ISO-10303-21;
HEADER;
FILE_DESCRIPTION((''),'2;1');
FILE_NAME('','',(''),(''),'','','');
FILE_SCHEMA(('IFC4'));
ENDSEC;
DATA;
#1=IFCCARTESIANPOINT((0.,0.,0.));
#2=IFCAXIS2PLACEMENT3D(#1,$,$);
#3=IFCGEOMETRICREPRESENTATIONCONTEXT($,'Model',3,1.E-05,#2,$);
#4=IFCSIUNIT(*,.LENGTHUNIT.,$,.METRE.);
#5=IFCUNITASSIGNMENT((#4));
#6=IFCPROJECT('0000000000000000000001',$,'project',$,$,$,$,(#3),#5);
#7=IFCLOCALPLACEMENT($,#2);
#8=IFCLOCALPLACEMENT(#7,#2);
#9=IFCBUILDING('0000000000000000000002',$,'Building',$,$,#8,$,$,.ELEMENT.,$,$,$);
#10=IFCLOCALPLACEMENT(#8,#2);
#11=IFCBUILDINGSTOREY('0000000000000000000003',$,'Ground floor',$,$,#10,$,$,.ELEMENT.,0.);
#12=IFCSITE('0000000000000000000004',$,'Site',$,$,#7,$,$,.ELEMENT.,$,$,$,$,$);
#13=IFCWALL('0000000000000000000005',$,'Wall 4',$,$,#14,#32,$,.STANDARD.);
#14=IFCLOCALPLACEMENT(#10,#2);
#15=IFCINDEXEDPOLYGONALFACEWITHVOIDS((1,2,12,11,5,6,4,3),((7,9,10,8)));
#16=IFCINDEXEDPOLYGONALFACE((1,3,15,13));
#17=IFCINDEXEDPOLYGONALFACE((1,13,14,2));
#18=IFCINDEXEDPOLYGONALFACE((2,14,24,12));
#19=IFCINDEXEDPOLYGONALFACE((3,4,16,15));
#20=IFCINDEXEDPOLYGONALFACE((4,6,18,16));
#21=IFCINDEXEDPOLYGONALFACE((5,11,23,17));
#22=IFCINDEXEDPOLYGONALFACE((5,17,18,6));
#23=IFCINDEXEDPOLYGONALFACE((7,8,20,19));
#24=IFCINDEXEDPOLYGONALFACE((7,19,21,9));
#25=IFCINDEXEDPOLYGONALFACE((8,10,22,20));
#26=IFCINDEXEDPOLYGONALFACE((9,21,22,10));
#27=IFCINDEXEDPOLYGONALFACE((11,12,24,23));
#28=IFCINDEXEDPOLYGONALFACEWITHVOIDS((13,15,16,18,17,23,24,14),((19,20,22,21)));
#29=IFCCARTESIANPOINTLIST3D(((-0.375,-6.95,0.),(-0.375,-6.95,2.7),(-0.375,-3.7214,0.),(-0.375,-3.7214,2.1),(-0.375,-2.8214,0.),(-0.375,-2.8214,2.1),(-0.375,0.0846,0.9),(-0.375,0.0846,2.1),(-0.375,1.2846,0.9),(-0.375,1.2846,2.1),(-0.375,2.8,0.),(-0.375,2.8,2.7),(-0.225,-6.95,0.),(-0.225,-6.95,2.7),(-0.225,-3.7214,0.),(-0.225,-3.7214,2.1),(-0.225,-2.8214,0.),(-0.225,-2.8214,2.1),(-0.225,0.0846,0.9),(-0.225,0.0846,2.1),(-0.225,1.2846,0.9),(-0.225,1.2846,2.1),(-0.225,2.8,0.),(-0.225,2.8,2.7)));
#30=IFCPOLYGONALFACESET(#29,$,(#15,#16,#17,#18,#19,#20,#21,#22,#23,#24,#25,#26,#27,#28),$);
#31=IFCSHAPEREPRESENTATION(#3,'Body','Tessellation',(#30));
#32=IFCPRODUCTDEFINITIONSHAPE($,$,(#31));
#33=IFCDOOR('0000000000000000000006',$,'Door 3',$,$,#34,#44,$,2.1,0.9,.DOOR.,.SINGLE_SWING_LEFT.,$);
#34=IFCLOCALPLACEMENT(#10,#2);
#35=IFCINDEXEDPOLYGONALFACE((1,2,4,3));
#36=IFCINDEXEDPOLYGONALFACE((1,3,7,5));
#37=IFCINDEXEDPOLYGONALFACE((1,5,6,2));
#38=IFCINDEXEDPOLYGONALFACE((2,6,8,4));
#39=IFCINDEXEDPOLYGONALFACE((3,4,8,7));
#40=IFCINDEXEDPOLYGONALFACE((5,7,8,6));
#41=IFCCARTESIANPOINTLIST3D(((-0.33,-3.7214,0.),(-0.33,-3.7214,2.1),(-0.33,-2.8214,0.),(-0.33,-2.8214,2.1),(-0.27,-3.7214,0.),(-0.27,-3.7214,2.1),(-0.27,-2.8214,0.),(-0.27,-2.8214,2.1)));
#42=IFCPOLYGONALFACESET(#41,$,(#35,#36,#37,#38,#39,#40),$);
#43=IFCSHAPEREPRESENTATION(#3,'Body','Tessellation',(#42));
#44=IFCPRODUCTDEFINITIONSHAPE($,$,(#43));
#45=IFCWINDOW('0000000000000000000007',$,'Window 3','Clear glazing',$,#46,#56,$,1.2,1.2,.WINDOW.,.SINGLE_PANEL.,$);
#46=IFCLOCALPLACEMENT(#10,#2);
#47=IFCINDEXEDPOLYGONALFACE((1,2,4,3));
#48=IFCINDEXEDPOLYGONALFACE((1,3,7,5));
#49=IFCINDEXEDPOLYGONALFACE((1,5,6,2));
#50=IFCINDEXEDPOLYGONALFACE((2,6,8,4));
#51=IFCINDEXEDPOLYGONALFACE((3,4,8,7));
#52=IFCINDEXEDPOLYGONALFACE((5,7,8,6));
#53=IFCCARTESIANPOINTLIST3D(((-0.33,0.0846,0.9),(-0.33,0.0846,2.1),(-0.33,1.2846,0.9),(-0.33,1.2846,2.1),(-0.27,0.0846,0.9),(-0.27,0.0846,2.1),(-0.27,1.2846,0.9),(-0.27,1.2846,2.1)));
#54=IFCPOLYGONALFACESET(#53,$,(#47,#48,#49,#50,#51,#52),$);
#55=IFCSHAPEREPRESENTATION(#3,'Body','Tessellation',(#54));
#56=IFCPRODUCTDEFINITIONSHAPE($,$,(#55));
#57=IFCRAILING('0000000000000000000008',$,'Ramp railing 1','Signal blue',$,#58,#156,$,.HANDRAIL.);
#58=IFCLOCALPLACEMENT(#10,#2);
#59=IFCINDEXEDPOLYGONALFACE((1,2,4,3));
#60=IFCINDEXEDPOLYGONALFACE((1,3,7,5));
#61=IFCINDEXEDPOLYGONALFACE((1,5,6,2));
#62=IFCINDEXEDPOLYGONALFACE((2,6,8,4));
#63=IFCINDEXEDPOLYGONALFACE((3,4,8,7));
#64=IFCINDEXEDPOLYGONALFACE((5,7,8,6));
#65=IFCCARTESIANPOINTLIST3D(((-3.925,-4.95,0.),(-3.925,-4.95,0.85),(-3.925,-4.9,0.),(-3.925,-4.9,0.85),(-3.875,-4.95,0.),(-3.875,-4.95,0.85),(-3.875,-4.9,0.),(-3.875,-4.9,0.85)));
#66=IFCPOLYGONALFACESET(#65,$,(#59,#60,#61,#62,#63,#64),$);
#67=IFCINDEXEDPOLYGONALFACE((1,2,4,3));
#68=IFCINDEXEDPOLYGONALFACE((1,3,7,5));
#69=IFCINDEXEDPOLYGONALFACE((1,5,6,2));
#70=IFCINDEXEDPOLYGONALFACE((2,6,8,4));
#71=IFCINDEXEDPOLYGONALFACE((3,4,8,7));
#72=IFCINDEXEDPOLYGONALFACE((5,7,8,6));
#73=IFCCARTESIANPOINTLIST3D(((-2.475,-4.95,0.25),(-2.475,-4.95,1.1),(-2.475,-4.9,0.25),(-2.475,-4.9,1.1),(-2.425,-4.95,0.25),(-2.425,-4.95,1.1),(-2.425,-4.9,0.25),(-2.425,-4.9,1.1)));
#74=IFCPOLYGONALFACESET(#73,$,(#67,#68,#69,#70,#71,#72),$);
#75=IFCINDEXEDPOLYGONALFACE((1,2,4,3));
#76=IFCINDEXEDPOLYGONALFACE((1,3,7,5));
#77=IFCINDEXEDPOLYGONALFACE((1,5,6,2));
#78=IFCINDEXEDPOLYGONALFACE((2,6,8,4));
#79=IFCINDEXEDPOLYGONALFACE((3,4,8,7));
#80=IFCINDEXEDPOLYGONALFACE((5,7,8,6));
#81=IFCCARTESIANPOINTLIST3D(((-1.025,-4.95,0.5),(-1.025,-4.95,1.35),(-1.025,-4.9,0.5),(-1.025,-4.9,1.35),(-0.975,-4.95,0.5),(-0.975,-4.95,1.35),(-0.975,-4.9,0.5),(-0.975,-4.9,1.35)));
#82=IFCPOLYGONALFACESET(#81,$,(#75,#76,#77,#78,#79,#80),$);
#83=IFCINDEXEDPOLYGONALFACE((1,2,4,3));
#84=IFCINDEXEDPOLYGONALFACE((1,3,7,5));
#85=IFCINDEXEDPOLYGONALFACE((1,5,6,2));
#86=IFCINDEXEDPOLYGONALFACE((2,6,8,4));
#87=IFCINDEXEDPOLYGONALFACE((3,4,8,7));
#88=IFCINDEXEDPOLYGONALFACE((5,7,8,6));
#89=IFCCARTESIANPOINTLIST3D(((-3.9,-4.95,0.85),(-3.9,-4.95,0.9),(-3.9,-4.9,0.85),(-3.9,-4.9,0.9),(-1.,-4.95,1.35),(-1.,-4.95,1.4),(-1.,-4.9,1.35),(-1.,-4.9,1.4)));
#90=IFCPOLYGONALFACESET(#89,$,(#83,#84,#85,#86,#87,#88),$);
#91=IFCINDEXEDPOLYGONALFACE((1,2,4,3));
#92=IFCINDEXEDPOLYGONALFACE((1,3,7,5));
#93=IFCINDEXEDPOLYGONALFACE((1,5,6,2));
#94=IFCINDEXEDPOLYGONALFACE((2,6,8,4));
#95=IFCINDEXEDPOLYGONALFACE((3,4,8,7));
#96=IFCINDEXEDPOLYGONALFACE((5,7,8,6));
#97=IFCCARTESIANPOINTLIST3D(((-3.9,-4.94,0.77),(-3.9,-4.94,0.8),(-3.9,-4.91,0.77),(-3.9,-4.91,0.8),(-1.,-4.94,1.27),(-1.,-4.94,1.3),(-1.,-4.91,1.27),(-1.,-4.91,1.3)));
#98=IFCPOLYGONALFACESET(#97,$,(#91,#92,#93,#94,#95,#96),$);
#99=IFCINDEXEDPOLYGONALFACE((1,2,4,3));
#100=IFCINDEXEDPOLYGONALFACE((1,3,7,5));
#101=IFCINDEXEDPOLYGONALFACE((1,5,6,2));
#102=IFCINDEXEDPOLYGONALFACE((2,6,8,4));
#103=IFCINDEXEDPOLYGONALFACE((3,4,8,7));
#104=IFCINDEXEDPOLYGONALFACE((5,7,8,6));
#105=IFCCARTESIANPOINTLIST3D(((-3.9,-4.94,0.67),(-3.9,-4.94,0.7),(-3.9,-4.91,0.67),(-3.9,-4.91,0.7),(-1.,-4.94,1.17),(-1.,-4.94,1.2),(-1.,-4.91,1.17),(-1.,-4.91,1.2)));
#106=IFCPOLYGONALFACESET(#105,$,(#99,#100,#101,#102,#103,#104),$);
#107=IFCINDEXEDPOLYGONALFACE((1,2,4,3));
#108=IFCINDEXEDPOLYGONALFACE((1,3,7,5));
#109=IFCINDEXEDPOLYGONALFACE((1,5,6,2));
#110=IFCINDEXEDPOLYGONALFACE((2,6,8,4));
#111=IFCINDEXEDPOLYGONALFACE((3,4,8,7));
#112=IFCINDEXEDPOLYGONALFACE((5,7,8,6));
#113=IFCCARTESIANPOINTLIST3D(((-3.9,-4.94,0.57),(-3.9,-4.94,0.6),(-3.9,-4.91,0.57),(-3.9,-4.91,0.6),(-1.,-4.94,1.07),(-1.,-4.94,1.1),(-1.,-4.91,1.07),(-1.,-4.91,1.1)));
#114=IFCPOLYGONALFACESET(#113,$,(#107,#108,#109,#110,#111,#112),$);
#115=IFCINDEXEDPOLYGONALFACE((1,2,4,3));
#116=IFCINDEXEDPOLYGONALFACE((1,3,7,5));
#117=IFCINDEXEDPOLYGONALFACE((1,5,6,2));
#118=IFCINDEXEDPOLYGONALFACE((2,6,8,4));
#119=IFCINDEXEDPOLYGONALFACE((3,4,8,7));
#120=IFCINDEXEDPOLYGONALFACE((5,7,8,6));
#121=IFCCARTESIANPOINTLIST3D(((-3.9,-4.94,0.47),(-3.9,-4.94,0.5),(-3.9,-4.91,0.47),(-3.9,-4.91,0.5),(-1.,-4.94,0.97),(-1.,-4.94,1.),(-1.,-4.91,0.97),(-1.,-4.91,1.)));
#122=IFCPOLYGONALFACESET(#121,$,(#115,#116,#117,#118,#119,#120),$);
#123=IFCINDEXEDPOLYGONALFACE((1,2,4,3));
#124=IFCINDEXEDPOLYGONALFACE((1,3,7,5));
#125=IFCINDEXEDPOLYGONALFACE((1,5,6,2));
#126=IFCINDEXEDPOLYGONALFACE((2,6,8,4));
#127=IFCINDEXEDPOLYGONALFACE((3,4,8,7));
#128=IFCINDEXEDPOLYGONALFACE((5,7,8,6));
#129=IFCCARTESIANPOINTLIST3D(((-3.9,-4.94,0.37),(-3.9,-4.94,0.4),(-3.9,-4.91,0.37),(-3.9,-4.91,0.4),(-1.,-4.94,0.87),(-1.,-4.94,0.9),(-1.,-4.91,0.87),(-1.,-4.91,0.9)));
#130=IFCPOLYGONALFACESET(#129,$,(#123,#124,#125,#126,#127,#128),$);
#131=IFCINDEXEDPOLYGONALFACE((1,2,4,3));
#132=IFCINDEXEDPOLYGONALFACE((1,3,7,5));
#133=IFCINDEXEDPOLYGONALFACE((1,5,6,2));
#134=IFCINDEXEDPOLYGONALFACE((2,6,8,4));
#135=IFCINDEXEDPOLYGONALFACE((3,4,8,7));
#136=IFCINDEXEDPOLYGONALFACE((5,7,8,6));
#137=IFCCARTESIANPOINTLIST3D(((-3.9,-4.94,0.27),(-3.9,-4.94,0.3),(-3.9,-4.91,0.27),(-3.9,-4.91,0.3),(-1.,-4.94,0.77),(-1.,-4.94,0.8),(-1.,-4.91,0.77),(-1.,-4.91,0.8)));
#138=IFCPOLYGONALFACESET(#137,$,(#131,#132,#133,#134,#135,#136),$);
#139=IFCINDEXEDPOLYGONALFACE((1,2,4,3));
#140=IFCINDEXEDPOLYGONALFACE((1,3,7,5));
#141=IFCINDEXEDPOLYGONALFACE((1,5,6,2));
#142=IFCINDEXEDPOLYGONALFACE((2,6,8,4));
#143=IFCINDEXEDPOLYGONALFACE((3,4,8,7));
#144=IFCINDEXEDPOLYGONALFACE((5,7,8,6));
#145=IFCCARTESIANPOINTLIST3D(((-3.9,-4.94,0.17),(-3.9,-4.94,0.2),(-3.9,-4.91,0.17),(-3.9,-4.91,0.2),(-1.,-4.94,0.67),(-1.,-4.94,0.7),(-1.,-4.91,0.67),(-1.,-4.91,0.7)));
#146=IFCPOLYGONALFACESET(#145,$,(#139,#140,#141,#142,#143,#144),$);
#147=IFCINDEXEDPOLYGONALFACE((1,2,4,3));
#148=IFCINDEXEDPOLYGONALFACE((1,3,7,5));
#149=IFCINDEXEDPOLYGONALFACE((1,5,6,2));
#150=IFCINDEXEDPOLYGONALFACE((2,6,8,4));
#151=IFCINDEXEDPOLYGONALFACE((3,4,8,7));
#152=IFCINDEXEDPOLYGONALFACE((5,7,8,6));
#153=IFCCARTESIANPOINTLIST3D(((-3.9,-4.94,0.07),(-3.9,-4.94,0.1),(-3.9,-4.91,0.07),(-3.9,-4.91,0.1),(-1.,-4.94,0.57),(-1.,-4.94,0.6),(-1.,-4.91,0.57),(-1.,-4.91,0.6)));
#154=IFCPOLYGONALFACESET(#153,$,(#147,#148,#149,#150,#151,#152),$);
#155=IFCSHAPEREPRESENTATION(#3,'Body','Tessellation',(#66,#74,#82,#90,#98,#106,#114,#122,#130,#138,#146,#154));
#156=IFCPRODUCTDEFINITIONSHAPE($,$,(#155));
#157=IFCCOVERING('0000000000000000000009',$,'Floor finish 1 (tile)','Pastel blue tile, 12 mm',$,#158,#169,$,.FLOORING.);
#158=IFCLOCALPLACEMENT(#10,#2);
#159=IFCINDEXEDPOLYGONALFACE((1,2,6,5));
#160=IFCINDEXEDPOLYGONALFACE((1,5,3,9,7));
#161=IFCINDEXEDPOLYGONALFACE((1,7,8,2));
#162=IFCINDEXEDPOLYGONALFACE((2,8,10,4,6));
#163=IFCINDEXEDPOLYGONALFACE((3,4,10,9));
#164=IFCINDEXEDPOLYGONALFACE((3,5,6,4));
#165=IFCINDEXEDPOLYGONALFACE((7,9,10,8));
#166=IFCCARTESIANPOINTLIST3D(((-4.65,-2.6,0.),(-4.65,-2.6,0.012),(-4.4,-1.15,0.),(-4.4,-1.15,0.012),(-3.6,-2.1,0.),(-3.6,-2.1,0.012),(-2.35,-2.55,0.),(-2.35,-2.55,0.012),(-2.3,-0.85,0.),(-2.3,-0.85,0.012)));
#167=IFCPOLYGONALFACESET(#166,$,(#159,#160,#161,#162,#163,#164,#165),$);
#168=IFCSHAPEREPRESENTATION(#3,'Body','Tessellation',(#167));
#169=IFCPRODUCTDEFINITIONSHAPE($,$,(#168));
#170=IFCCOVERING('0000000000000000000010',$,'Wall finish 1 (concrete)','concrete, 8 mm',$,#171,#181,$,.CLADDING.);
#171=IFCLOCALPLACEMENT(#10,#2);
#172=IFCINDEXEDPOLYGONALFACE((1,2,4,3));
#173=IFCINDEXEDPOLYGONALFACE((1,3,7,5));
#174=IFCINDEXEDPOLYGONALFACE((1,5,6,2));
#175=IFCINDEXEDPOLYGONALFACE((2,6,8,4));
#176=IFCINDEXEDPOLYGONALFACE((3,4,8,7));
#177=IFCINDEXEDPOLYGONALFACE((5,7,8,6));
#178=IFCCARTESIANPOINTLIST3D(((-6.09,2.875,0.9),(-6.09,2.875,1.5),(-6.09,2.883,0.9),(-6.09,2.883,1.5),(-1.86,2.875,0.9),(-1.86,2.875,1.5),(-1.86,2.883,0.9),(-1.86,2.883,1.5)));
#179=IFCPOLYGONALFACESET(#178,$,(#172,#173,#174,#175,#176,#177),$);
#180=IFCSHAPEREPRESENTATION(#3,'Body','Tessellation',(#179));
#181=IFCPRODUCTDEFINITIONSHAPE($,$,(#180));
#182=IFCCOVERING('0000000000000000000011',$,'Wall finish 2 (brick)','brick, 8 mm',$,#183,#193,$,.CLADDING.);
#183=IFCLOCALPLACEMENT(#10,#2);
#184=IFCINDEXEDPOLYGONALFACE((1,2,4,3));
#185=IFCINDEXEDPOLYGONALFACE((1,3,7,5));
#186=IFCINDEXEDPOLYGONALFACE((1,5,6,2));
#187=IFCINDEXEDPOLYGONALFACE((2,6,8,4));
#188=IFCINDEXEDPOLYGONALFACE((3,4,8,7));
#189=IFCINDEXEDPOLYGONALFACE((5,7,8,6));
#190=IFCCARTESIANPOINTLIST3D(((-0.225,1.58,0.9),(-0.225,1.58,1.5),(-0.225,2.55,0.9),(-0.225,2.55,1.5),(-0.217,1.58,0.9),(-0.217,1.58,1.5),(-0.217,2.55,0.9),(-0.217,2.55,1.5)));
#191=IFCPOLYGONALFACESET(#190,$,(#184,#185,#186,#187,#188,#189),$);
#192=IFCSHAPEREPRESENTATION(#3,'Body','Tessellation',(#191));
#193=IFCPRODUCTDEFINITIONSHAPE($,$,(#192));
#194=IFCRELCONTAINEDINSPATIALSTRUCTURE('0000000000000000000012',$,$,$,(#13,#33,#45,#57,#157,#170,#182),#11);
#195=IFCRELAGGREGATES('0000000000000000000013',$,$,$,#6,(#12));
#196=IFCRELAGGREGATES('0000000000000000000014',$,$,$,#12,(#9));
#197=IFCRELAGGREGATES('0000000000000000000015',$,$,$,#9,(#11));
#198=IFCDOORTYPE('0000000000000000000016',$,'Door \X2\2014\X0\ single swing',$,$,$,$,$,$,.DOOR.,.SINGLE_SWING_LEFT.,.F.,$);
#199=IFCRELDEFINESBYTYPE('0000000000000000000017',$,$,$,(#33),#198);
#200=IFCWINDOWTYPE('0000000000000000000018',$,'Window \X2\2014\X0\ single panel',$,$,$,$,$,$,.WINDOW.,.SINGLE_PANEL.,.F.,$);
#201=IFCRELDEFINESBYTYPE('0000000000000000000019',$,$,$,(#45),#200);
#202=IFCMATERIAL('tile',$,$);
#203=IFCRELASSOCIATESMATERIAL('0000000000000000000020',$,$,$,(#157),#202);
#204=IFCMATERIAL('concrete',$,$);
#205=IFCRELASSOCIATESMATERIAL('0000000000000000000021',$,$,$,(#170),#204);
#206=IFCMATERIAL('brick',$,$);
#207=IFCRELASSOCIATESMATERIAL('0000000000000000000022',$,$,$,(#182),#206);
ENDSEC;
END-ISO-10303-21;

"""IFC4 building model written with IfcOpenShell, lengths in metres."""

from ifc_helpers import new_model, si_unit, frame, frame_2d, origin, origin_with_axes, place, context, project, spatial, polyline, rectangle, outline, extrude, material, type_object, element, fill, save


model = new_model("IFC4")

# Units and contexts
model_context = context("Model", 3, precision=1e-05, world=origin())
ifc_project = project(units=[si_unit("LENGTHUNIT", "METRE")], contexts=[model_context])

# Site, building, storey
site_placement = place(None, origin())
site = spatial("IfcSite", under=ifc_project, at=site_placement, Name="Site", CompositionType="ELEMENT")
building_placement = place(site_placement, origin())
building = spatial("IfcBuilding", under=site, at=building_placement, Name="Building", CompositionType="ELEMENT")
storey_placement = place(building_placement, origin())
storey = spatial("IfcBuildingStorey", under=building, at=storey_placement, Name="Ground floor", CompositionType="ELEMENT", Elevation=0.0)

# Shared definitions
door_type = type_object("IfcDoorType", Name="Door — single swing", OperationType="SINGLE_SWING_LEFT", ParameterTakesPrecedence=False, PredefinedType="DOOR")
window_type_1 = type_object("IfcWindowType", Name="Window — single panel", ParameterTakesPrecedence=False, PartitioningType="SINGLE_PANEL", PredefinedType="WINDOW")

# Wall, openings, door, window
wall_1_placement = place(storey_placement, frame((-0.3, 2.8, 0.0), z_axis=(0.0, 0.0, 1.0), x_axis=(0.0, -1.0, 0.0)))
wall_1 = element("IfcWall", 1, at=wall_1_placement, inside=storey, Name="Wall 4", PredefinedType="STANDARD", context=model_context, shape_type="SweptSolid", body=[
    extrude(rectangle(XDim=9.75, YDim=0.15, at=frame_2d((4.875, 0.0))), origin(), (0.0, 0.0, 1.0), 2.7),
])
opening_1_placement = place(storey_placement, frame((-0.3, 1.2846, 0.9), z_axis=(0.0, 0.0, 1.0), x_axis=(0.0, -1.0, 0.0)))
opening_1 = element("IfcOpeningElement", 2, at=opening_1_placement, cuts=wall_1, PredefinedType="OPENING", context=model_context, shape_type="SweptSolid", body=[
    extrude(rectangle(XDim=1.2, YDim=0.21, at=frame_2d((0.6, 0.0))), origin(), (0.0, 0.0, 1.0), 1.2),
])
opening_2_placement = place(storey_placement, frame((-0.3, -2.8214, 0.0), z_axis=(0.0, 0.0, 1.0), x_axis=(0.0, -1.0, 0.0)))
opening_2 = element("IfcOpeningElement", 3, at=opening_2_placement, cuts=wall_1, PredefinedType="OPENING", context=model_context, shape_type="SweptSolid", body=[
    extrude(rectangle(XDim=0.9, YDim=0.21, at=frame_2d((0.45, 0.0))), origin(), (0.0, 0.0, 1.0), 2.1),
])
door_1_placement = place(storey_placement, frame((-0.3, -2.8214, 0.0), z_axis=(0.0, 0.0, 1.0), x_axis=(0.0, -1.0, 0.0)))
door_1 = element("IfcDoor", 4, at=door_1_placement, inside=storey, type_object=door_type, Name="Door 3", OperationType="SINGLE_SWING_LEFT", OverallHeight=2.1, OverallWidth=0.9, PredefinedType="DOOR", context=model_context, shape_type="SweptSolid", body=[
    extrude(rectangle(XDim=0.9, YDim=0.06, at=frame_2d((0.45, 0.0))), origin(), (0.0, 0.0, 1.0), 2.1),
])
fill(opening_2, door_1)
window_1_placement = place(storey_placement, frame((-0.3, 1.2846, 0.9), z_axis=(0.0, 0.0, 1.0), x_axis=(0.0, -1.0, 0.0)))
window_1 = element("IfcWindow", 5, at=window_1_placement, inside=storey, type_object=window_type_1, Name="Window 3", Description="Clear glazing", OverallHeight=1.2, OverallWidth=1.2, PartitioningType="SINGLE_PANEL", PredefinedType="WINDOW", context=model_context, shape_type="SweptSolid", body=[
    extrude(rectangle(XDim=1.2, YDim=0.06, at=frame_2d((0.6, 0.0))), origin(), (0.0, 0.0, 1.0), 1.2),
])
fill(opening_1, window_1)

# Railing
railing_placement = place(storey_placement, frame((-3.9, -5.5, 0.0), z_axis=(0.0, 0.0, 1.0), x_axis=(1.0, 0.0, 0.0)))
element("IfcRailing", 6, at=railing_placement, inside=storey, Name="Ramp railing 1", Description="Signal blue", PredefinedType="HANDRAIL", context=model_context, shape_type="SweptSolid", body=[
    extrude(rectangle(XDim=0.05, YDim=0.05, at=frame_2d((0.0, 0.575))), origin(), (0.0, 0.0, 1.0), 0.85),
    extrude(rectangle(XDim=0.05, YDim=0.05, at=frame_2d((1.45, 0.575))), frame((0.0, 0.0, 0.25)), (0.0, 0.0, 1.0), 0.85),
    extrude(rectangle(XDim=0.05, YDim=0.05, at=frame_2d((2.9, 0.575))), frame((0.0, 0.0, 0.5)), (0.0, 0.0, 1.0), 0.85),
    extrude(outline(polyline([(0.0, 0.85), (2.9, 1.35), (2.9, 1.4), (0.0, 0.9), (0.0, 0.85)])), frame((0.0, 0.6, 0.0), z_axis=(0.0, -1.0, 0.0), x_axis=(1.0, 0.0, 0.0)), (0.0, 0.0, 1.0), 0.05),
    extrude(outline(polyline([(0.0, 0.77), (2.9, 1.27), (2.9, 1.3), (0.0, 0.8), (0.0, 0.77)])), frame((0.0, 0.59, 0.0), z_axis=(0.0, -1.0, 0.0), x_axis=(1.0, 0.0, 0.0)), (0.0, 0.0, 1.0), 0.03),
    extrude(outline(polyline([(0.0, 0.67), (2.9, 1.17), (2.9, 1.2), (0.0, 0.7), (0.0, 0.67)])), frame((0.0, 0.59, 0.0), z_axis=(0.0, -1.0, 0.0), x_axis=(1.0, 0.0, 0.0)), (0.0, 0.0, 1.0), 0.03),
    extrude(outline(polyline([(0.0, 0.57), (2.9, 1.07), (2.9, 1.1), (0.0, 0.6), (0.0, 0.57)])), frame((0.0, 0.59, 0.0), z_axis=(0.0, -1.0, 0.0), x_axis=(1.0, 0.0, 0.0)), (0.0, 0.0, 1.0), 0.03),
    extrude(outline(polyline([(0.0, 0.47), (2.9, 0.97), (2.9, 1.0), (0.0, 0.5), (0.0, 0.47)])), frame((0.0, 0.59, 0.0), z_axis=(0.0, -1.0, 0.0), x_axis=(1.0, 0.0, 0.0)), (0.0, 0.0, 1.0), 0.03),
    extrude(outline(polyline([(0.0, 0.37), (2.9, 0.87), (2.9, 0.9), (0.0, 0.4), (0.0, 0.37)])), frame((0.0, 0.59, 0.0), z_axis=(0.0, -1.0, 0.0), x_axis=(1.0, 0.0, 0.0)), (0.0, 0.0, 1.0), 0.03),
    extrude(outline(polyline([(0.0, 0.27), (2.9, 0.77), (2.9, 0.8), (0.0, 0.3), (0.0, 0.27)])), frame((0.0, 0.59, 0.0), z_axis=(0.0, -1.0, 0.0), x_axis=(1.0, 0.0, 0.0)), (0.0, 0.0, 1.0), 0.03),
    extrude(outline(polyline([(0.0, 0.17), (2.9, 0.67), (2.9, 0.7), (0.0, 0.2), (0.0, 0.17)])), frame((0.0, 0.59, 0.0), z_axis=(0.0, -1.0, 0.0), x_axis=(1.0, 0.0, 0.0)), (0.0, 0.0, 1.0), 0.03),
    extrude(outline(polyline([(0.0, 0.07), (2.9, 0.57), (2.9, 0.6), (0.0, 0.1), (0.0, 0.07)])), frame((0.0, 0.59, 0.0), z_axis=(0.0, -1.0, 0.0), x_axis=(1.0, 0.0, 0.0)), (0.0, 0.0, 1.0), 0.03),
])

# Coverings
ifc_material_1 = material(Name="tile")
covering_1_placement = place(storey_placement, origin_with_axes())
element("IfcCovering", 7, at=covering_1_placement, inside=storey, material=ifc_material_1, Name="Floor finish 1 (tile)", Description="Pastel blue tile, 12 mm", PredefinedType="FLOORING", context=model_context, shape_type="SweptSolid", body=[
    extrude(outline(polyline([(-3.6, -2.1), (-4.65, -2.6), (-2.35, -2.55), (-2.3, -0.85), (-4.4, -1.15), (-3.6, -2.1)])), origin(), (0.0, 0.0, 1.0), 0.012),
])
ifc_material_2 = material(Name="concrete")
covering_2_placement = place(storey_placement, origin_with_axes())
element("IfcCovering", 8, at=covering_2_placement, inside=storey, material=ifc_material_2, Name="Wall finish 1 (concrete)", Description="concrete, 8 mm", PredefinedType="CLADDING", context=model_context, shape_type="SweptSolid", body=[
    extrude(outline(polyline([(-6.09, 2.875), (-1.86, 2.875), (-1.86, 2.883), (-6.09, 2.883), (-6.09, 2.875)])), frame((0.0, 0.0, 0.9)), (0.0, 0.0, 1.0), 0.6),
])
ifc_material_3 = material(Name="brick")
covering_3_placement = place(storey_placement, origin_with_axes())
element("IfcCovering", 9, at=covering_3_placement, inside=storey, material=ifc_material_3, Name="Wall finish 2 (brick)", Description="brick, 8 mm", PredefinedType="CLADDING", context=model_context, shape_type="SweptSolid", body=[
    extrude(outline(polyline([(-0.225, 2.55), (-0.225, 1.58), (-0.217, 1.58), (-0.217, 2.55), (-0.225, 2.55)])), frame((0.0, 0.0, 0.9)), (0.0, 0.0, 1.0), 0.6),
])

save(model, "model.ifc")
